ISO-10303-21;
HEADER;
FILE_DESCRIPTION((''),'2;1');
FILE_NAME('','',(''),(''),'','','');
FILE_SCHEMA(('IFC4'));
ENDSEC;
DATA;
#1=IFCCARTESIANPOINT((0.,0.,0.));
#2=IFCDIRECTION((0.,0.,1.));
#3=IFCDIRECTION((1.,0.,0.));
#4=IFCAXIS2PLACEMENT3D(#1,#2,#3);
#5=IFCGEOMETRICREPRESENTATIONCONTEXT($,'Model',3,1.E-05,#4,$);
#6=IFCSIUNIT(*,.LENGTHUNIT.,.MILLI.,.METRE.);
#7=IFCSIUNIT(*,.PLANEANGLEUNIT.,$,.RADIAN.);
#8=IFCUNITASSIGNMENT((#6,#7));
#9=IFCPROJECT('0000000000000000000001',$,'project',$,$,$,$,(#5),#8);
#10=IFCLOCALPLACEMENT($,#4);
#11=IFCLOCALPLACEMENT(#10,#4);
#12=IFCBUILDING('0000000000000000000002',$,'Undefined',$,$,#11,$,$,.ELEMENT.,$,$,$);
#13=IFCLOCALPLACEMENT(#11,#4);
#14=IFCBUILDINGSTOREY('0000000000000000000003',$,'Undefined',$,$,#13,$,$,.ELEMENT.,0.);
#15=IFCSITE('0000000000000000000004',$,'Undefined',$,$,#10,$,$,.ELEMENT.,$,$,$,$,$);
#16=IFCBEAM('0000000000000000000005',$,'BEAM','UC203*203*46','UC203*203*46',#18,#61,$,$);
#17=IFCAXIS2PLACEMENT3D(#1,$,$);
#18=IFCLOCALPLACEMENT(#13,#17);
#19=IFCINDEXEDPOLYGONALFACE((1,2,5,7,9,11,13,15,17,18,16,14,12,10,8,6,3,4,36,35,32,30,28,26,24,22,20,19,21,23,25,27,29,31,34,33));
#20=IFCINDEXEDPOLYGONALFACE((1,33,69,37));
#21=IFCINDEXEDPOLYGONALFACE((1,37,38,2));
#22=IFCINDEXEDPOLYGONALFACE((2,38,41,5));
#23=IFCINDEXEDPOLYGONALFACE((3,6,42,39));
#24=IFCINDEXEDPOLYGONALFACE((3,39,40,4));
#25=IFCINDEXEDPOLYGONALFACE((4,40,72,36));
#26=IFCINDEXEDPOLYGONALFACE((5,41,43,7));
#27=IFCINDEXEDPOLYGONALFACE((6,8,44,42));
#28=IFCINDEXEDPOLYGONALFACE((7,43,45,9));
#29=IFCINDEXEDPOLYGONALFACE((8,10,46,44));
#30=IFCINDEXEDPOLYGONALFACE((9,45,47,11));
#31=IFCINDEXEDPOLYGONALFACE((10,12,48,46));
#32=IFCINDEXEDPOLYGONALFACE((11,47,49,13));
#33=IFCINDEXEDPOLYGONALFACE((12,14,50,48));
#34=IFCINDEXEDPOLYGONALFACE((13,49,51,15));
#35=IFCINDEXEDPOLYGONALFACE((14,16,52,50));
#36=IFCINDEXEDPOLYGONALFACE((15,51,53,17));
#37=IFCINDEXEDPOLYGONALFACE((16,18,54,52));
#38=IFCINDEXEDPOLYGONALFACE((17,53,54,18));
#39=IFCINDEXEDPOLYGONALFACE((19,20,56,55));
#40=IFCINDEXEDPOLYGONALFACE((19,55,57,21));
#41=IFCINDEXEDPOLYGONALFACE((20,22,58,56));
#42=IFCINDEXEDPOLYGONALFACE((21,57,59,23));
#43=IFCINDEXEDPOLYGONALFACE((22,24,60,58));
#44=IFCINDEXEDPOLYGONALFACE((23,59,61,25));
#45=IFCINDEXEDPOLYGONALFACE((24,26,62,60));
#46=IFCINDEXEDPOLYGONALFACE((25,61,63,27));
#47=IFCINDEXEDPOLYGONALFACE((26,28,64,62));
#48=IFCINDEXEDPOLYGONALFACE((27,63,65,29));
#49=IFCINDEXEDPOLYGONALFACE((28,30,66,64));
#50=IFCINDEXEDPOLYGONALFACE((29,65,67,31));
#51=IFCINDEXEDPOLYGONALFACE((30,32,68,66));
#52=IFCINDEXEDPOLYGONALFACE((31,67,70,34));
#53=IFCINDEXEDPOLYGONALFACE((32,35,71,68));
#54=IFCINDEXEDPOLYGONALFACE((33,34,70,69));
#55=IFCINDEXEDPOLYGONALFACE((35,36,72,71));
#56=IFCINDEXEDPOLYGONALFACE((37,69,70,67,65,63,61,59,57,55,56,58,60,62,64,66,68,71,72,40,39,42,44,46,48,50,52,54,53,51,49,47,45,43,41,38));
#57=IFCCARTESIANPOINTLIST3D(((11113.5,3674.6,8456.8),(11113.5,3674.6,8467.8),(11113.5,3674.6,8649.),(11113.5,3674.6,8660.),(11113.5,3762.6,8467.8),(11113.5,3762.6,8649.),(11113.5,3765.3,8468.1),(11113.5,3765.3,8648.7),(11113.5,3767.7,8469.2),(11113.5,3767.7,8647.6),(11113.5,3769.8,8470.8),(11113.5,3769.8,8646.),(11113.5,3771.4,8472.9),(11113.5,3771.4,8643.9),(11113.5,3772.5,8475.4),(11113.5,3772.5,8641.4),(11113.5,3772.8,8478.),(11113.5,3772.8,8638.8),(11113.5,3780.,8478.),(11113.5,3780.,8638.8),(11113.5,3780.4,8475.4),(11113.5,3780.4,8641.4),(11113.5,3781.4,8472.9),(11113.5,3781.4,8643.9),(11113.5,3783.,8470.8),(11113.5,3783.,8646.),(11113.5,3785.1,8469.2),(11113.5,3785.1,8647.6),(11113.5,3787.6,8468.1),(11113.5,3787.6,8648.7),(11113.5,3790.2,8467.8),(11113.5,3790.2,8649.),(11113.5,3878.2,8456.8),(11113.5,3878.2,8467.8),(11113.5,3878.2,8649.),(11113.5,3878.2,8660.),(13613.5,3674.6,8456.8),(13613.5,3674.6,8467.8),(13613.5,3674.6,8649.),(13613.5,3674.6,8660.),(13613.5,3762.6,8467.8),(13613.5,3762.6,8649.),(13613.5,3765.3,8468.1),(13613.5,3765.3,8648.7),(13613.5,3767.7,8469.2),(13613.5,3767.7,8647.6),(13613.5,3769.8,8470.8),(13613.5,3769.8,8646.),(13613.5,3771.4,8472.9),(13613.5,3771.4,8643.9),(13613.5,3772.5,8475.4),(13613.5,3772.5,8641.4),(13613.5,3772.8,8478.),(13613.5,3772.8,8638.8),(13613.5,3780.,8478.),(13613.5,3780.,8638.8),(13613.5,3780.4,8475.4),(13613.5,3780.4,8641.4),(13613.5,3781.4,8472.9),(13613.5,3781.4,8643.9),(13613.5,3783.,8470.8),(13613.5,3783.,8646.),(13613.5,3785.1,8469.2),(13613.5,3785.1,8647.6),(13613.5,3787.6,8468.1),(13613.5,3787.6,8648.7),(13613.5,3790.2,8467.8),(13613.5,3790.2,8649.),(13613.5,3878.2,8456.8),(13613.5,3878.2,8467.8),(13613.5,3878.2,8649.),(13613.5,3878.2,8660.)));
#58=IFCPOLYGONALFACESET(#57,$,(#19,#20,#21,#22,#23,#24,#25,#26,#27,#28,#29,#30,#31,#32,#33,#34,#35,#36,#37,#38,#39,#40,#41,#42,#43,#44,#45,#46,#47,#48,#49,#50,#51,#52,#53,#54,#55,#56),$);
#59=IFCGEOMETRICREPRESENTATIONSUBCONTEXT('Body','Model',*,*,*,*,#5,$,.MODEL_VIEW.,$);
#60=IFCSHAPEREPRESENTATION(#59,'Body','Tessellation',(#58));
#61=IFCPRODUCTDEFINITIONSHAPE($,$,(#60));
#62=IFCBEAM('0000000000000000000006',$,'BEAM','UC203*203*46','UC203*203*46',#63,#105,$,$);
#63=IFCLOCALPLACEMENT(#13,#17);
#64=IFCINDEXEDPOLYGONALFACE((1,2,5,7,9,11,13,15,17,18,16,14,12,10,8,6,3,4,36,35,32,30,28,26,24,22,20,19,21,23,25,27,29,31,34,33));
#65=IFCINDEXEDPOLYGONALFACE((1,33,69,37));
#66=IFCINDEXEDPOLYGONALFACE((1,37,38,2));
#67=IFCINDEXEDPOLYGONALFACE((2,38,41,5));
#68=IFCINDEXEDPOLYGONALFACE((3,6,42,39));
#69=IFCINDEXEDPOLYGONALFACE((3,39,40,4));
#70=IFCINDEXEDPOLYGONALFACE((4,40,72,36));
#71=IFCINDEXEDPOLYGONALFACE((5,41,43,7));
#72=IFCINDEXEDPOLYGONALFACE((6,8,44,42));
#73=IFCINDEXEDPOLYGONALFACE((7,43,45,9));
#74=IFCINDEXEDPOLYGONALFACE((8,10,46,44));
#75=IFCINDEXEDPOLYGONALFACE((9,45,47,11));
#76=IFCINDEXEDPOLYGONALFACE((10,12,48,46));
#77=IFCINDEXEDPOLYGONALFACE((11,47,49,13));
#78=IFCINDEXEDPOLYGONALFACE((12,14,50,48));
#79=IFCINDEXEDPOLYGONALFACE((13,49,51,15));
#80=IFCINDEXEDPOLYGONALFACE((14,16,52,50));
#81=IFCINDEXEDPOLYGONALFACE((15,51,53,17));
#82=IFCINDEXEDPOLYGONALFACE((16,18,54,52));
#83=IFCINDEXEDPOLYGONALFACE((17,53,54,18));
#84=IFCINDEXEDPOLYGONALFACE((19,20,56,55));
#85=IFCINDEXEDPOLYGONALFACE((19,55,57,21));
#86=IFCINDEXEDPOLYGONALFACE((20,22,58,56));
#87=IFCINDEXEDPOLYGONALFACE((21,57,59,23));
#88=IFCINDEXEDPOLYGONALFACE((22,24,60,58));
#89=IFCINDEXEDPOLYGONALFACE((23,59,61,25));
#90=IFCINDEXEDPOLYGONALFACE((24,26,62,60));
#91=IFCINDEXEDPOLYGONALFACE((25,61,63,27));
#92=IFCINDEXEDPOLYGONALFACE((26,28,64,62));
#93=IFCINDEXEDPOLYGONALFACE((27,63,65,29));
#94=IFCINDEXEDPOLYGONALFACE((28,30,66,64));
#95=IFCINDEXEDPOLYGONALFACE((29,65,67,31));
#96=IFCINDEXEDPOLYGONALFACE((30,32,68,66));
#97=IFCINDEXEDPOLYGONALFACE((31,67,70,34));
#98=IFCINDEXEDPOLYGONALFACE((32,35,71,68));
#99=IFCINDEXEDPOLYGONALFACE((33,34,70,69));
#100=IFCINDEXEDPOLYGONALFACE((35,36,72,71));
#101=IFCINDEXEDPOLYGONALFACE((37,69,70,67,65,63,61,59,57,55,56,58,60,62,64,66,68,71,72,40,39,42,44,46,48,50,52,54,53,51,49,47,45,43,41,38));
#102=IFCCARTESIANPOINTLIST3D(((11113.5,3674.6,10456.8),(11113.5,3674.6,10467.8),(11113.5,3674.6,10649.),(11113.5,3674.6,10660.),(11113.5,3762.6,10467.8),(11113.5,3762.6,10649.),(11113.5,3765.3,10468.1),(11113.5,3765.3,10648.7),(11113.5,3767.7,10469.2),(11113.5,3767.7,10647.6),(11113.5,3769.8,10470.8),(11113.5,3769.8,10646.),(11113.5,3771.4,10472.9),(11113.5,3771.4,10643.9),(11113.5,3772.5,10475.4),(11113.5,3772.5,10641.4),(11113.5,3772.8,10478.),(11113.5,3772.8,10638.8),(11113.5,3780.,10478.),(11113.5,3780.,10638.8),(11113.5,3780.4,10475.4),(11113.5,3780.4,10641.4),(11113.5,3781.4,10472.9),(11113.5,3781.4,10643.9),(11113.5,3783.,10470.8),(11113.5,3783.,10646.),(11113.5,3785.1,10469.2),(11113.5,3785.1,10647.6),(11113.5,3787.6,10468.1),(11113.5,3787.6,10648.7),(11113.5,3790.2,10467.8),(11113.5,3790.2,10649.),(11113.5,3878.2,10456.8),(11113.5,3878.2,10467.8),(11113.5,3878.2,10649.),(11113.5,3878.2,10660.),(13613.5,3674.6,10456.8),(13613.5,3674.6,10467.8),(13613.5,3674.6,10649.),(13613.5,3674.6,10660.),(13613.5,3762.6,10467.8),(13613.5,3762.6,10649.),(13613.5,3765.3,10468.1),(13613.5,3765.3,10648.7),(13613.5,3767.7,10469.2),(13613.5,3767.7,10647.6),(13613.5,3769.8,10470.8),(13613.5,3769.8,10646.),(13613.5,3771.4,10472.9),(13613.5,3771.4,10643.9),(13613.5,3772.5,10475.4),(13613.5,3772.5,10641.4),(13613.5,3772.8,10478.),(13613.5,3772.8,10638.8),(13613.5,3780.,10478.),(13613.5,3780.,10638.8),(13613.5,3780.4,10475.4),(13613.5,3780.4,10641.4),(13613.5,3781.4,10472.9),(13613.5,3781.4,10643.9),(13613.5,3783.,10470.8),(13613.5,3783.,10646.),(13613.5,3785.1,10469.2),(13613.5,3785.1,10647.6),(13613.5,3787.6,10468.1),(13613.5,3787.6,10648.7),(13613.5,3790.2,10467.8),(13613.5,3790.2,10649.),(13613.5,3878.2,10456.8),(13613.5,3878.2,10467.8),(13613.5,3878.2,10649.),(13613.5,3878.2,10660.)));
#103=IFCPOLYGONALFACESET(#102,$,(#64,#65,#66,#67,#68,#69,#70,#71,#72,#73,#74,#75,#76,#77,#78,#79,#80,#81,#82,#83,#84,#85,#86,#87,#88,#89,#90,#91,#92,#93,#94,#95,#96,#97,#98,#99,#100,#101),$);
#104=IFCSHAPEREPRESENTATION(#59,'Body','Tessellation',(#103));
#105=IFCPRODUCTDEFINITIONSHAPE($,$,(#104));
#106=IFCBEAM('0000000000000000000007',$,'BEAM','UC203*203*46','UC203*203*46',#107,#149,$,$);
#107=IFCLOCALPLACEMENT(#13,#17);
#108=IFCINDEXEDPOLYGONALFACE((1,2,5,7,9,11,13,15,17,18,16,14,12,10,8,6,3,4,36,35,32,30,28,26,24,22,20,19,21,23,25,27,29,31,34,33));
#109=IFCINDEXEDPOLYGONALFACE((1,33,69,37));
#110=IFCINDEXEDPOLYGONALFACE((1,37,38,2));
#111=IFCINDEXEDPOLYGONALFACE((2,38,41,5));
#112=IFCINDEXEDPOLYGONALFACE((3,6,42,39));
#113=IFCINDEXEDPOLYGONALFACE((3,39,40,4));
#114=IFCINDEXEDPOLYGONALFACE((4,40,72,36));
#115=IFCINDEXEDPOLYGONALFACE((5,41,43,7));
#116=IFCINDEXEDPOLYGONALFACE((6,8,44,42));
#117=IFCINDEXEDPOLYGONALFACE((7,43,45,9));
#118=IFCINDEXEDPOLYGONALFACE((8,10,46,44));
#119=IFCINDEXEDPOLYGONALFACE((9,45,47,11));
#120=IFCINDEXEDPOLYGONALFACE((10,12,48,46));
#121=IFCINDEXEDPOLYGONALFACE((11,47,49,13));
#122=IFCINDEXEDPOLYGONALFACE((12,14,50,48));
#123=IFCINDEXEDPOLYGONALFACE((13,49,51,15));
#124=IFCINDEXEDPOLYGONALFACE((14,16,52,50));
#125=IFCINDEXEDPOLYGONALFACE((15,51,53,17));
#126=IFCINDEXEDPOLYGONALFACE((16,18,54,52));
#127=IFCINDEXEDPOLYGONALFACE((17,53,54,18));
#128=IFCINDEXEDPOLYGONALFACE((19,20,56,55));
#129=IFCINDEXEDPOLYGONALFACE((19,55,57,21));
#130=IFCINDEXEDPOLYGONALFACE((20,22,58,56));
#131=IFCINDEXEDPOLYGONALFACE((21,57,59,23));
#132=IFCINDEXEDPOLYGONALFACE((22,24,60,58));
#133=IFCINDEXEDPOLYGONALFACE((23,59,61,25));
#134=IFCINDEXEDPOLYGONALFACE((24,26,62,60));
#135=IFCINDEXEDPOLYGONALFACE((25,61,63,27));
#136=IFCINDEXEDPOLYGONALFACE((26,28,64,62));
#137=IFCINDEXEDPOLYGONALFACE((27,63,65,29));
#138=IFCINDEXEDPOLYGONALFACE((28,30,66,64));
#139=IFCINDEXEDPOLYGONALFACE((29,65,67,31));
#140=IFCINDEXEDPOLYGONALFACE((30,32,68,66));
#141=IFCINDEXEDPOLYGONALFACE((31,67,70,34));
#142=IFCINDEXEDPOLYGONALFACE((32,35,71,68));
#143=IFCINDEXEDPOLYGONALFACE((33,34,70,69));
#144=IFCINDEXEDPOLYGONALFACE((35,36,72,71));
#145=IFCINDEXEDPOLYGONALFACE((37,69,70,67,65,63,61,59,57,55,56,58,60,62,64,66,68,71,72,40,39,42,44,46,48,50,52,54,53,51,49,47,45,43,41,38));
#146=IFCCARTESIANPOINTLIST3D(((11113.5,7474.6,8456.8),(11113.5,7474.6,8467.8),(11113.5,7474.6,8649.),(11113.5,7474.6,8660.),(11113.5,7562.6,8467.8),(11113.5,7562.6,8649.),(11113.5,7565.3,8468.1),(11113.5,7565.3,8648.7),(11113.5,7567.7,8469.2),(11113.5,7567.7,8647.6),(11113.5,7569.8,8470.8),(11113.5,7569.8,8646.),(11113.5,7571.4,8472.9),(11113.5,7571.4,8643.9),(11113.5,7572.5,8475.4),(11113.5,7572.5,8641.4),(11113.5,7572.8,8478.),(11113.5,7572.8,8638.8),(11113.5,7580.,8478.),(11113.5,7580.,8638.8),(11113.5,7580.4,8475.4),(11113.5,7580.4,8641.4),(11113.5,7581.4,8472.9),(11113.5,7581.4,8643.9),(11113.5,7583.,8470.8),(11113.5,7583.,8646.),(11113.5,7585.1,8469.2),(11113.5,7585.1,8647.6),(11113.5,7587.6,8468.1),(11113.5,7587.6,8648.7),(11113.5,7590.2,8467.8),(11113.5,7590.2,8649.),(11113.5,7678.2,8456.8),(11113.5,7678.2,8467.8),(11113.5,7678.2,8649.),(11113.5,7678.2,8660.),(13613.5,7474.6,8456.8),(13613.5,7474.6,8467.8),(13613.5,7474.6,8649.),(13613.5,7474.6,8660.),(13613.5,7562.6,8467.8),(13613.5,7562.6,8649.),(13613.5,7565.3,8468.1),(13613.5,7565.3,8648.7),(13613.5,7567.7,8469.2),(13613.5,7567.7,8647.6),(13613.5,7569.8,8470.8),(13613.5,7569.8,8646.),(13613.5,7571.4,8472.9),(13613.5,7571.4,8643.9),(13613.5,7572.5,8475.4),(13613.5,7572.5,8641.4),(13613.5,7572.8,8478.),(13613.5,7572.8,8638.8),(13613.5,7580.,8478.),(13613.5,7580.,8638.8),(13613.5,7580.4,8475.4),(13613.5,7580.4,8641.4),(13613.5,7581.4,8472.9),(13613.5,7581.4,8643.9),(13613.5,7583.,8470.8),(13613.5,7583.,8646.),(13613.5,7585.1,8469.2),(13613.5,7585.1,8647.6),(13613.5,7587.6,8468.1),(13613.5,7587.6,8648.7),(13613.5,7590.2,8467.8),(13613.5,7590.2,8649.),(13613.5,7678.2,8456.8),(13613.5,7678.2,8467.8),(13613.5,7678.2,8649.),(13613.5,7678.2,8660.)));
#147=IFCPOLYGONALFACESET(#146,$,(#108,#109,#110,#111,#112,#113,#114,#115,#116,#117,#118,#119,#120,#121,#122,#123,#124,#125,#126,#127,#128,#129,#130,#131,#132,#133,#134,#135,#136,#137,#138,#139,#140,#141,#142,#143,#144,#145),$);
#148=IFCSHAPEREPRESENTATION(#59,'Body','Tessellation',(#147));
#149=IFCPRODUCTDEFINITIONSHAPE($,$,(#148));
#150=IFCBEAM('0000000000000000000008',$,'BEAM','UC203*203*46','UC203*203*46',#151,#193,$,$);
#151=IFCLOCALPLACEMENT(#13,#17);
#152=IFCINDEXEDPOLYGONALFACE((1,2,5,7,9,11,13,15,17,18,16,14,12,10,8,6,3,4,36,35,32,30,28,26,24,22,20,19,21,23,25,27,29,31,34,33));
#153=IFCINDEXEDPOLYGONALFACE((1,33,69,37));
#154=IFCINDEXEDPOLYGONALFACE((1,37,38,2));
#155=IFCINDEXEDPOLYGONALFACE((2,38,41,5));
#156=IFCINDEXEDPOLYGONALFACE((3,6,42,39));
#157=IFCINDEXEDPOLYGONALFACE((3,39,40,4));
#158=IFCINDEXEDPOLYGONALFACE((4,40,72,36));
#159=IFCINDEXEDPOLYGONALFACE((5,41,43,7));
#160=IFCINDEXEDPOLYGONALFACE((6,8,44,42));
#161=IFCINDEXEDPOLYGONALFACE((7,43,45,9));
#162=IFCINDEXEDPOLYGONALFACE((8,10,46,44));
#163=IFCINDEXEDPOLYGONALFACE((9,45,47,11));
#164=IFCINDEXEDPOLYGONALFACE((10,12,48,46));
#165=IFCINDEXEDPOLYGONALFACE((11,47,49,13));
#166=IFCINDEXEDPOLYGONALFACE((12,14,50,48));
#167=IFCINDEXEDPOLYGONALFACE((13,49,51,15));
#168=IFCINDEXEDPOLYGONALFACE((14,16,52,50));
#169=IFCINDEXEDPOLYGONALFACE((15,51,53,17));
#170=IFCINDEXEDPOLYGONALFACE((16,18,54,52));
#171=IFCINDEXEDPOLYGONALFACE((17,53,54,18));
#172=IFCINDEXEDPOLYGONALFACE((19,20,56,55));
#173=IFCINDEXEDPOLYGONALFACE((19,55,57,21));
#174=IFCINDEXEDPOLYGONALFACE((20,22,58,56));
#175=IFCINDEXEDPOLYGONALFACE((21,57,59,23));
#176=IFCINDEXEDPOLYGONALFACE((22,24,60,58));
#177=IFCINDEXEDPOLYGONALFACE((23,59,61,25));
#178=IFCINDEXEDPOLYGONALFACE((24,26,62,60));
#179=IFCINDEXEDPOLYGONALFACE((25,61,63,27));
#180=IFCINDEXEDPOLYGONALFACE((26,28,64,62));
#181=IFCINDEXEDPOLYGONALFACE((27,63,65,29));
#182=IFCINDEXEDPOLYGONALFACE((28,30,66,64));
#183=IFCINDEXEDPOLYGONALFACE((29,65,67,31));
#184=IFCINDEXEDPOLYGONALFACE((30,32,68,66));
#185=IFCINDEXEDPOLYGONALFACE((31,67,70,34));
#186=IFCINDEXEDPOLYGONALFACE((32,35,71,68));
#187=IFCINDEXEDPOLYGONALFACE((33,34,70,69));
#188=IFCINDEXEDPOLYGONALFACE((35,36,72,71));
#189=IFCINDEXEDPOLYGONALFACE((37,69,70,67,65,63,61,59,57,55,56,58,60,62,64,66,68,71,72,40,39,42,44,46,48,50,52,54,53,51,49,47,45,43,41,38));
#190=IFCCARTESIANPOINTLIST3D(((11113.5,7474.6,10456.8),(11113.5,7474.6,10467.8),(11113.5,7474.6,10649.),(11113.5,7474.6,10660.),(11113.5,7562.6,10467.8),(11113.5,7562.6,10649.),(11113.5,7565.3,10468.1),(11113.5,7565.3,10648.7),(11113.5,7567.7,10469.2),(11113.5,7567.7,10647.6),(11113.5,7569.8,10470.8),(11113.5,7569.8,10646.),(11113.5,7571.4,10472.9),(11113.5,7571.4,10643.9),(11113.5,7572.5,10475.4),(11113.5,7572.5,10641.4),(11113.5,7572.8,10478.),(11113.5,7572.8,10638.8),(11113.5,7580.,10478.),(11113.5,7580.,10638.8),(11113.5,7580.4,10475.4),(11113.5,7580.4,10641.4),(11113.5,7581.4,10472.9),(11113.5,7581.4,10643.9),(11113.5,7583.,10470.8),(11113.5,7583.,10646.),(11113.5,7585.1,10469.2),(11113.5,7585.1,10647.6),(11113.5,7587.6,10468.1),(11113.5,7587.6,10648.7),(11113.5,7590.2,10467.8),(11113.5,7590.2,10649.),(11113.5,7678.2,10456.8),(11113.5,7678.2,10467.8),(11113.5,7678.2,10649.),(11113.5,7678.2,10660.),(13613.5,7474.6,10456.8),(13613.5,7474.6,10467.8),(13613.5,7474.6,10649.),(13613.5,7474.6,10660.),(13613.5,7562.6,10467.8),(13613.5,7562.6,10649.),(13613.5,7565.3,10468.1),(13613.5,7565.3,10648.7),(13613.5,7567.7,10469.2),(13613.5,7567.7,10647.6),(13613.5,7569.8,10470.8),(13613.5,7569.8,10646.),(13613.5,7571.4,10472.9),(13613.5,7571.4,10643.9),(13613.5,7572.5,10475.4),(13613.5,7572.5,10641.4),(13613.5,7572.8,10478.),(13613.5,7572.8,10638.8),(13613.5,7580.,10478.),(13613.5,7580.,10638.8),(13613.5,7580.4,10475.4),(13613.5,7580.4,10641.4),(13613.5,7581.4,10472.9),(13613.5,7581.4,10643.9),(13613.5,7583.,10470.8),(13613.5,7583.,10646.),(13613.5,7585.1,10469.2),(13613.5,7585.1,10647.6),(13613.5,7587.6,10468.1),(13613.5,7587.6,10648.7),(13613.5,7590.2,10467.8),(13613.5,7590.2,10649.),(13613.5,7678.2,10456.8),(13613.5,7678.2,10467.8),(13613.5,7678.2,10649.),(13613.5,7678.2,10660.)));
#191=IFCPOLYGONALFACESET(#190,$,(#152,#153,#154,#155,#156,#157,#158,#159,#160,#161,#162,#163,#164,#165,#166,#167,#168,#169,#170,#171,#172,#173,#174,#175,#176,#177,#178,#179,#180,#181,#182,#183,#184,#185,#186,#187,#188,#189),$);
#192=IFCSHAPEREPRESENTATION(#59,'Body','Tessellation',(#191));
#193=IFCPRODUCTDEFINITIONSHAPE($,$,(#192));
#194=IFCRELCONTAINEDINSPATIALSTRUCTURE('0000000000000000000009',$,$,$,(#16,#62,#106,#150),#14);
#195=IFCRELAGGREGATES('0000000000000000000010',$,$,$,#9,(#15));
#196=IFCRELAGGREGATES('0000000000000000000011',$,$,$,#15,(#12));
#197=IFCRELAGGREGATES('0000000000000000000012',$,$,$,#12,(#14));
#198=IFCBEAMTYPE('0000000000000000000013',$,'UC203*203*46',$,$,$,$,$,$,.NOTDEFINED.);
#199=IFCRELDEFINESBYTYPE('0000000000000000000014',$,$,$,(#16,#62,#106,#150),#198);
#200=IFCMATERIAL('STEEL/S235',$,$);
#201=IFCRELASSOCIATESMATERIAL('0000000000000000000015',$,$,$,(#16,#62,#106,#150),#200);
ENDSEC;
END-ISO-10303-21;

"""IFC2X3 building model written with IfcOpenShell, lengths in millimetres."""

from ifc_helpers import new_model, si_unit, frame, origin_with_axes, origin_2d_with_axis, place, context, subcontext, project, spatial, i_section, extrude, material, type_object, element, save


model = new_model("IFC2X3")

# Units and contexts
model_context = context("Model", 3, precision=1e-05, world=origin_with_axes())
body_context = subcontext(model_context, "Body", "Model", "MODEL_VIEW")
ifc_project = project(units=[si_unit("LENGTHUNIT", "METRE", prefix="MILLI"), si_unit("PLANEANGLEUNIT", "RADIAN")], contexts=[model_context])

# Site, building, storey
site_placement = place(None, origin_with_axes())
site = spatial("IfcSite", under=ifc_project, at=site_placement, Name="Undefined", CompositionType="ELEMENT")
building_placement = place(site_placement, origin_with_axes())
building = spatial("IfcBuilding", under=site, at=building_placement, Name="Undefined", CompositionType="ELEMENT")
storey_placement = place(building_placement, origin_with_axes())
storey = spatial("IfcBuildingStorey", under=building, at=storey_placement, Name="Undefined", CompositionType="ELEMENT", Elevation=0.0)

# Shared definitions
ifc_material = material(Name="STEEL/S235")

# Beams
beam_type_1 = type_object("IfcBeamType", Name="UC203*203*46", PredefinedType="NOTDEFINED")
for number, where, z_axis, x_axis, name in (
    (1, (11113.5, 3776.4, 8558.4), (0.0, 0.0, 1.0), (1.0, 0.0, 0.0), "BEAM"),
    (2, (11113.5, 3776.4, 10558.4), (0.0, 0.0, 1.0), (1.0, 0.0, 0.0), "BEAM"),
    (3, (11113.5, 7576.4, 8558.4), (0.0, 0.0, 1.0), (1.0, 0.0, 0.0), "BEAM"),
    (4, (11113.5, 7576.4, 10558.4), (0.0, 0.0, 1.0), (1.0, 0.0, 0.0), "BEAM"),
):
    element("IfcBeam", number, at=place(storey_placement, frame(where, z_axis=z_axis, x_axis=x_axis)), inside=storey, type_object=beam_type_1, material=ifc_material, Name=name, Description="UC203*203*46", ObjectType="UC203*203*46", context=body_context, shape_type="SweptSolid", body=[
        extrude(i_section(OverallWidth=203.6, OverallDepth=203.2, WebThickness=7.2, FlangeThickness=11.0, FilletRadius=10.2, at=origin_2d_with_axis()), frame((2500.0, 0.0, 0.0), z_axis=(-1.0, 0.0, 0.0), x_axis=(0.0, -1.0, 0.0)), (0.0, 0.0, 1.0), 2500.0),
    ])

save(model, "model.ifc")
